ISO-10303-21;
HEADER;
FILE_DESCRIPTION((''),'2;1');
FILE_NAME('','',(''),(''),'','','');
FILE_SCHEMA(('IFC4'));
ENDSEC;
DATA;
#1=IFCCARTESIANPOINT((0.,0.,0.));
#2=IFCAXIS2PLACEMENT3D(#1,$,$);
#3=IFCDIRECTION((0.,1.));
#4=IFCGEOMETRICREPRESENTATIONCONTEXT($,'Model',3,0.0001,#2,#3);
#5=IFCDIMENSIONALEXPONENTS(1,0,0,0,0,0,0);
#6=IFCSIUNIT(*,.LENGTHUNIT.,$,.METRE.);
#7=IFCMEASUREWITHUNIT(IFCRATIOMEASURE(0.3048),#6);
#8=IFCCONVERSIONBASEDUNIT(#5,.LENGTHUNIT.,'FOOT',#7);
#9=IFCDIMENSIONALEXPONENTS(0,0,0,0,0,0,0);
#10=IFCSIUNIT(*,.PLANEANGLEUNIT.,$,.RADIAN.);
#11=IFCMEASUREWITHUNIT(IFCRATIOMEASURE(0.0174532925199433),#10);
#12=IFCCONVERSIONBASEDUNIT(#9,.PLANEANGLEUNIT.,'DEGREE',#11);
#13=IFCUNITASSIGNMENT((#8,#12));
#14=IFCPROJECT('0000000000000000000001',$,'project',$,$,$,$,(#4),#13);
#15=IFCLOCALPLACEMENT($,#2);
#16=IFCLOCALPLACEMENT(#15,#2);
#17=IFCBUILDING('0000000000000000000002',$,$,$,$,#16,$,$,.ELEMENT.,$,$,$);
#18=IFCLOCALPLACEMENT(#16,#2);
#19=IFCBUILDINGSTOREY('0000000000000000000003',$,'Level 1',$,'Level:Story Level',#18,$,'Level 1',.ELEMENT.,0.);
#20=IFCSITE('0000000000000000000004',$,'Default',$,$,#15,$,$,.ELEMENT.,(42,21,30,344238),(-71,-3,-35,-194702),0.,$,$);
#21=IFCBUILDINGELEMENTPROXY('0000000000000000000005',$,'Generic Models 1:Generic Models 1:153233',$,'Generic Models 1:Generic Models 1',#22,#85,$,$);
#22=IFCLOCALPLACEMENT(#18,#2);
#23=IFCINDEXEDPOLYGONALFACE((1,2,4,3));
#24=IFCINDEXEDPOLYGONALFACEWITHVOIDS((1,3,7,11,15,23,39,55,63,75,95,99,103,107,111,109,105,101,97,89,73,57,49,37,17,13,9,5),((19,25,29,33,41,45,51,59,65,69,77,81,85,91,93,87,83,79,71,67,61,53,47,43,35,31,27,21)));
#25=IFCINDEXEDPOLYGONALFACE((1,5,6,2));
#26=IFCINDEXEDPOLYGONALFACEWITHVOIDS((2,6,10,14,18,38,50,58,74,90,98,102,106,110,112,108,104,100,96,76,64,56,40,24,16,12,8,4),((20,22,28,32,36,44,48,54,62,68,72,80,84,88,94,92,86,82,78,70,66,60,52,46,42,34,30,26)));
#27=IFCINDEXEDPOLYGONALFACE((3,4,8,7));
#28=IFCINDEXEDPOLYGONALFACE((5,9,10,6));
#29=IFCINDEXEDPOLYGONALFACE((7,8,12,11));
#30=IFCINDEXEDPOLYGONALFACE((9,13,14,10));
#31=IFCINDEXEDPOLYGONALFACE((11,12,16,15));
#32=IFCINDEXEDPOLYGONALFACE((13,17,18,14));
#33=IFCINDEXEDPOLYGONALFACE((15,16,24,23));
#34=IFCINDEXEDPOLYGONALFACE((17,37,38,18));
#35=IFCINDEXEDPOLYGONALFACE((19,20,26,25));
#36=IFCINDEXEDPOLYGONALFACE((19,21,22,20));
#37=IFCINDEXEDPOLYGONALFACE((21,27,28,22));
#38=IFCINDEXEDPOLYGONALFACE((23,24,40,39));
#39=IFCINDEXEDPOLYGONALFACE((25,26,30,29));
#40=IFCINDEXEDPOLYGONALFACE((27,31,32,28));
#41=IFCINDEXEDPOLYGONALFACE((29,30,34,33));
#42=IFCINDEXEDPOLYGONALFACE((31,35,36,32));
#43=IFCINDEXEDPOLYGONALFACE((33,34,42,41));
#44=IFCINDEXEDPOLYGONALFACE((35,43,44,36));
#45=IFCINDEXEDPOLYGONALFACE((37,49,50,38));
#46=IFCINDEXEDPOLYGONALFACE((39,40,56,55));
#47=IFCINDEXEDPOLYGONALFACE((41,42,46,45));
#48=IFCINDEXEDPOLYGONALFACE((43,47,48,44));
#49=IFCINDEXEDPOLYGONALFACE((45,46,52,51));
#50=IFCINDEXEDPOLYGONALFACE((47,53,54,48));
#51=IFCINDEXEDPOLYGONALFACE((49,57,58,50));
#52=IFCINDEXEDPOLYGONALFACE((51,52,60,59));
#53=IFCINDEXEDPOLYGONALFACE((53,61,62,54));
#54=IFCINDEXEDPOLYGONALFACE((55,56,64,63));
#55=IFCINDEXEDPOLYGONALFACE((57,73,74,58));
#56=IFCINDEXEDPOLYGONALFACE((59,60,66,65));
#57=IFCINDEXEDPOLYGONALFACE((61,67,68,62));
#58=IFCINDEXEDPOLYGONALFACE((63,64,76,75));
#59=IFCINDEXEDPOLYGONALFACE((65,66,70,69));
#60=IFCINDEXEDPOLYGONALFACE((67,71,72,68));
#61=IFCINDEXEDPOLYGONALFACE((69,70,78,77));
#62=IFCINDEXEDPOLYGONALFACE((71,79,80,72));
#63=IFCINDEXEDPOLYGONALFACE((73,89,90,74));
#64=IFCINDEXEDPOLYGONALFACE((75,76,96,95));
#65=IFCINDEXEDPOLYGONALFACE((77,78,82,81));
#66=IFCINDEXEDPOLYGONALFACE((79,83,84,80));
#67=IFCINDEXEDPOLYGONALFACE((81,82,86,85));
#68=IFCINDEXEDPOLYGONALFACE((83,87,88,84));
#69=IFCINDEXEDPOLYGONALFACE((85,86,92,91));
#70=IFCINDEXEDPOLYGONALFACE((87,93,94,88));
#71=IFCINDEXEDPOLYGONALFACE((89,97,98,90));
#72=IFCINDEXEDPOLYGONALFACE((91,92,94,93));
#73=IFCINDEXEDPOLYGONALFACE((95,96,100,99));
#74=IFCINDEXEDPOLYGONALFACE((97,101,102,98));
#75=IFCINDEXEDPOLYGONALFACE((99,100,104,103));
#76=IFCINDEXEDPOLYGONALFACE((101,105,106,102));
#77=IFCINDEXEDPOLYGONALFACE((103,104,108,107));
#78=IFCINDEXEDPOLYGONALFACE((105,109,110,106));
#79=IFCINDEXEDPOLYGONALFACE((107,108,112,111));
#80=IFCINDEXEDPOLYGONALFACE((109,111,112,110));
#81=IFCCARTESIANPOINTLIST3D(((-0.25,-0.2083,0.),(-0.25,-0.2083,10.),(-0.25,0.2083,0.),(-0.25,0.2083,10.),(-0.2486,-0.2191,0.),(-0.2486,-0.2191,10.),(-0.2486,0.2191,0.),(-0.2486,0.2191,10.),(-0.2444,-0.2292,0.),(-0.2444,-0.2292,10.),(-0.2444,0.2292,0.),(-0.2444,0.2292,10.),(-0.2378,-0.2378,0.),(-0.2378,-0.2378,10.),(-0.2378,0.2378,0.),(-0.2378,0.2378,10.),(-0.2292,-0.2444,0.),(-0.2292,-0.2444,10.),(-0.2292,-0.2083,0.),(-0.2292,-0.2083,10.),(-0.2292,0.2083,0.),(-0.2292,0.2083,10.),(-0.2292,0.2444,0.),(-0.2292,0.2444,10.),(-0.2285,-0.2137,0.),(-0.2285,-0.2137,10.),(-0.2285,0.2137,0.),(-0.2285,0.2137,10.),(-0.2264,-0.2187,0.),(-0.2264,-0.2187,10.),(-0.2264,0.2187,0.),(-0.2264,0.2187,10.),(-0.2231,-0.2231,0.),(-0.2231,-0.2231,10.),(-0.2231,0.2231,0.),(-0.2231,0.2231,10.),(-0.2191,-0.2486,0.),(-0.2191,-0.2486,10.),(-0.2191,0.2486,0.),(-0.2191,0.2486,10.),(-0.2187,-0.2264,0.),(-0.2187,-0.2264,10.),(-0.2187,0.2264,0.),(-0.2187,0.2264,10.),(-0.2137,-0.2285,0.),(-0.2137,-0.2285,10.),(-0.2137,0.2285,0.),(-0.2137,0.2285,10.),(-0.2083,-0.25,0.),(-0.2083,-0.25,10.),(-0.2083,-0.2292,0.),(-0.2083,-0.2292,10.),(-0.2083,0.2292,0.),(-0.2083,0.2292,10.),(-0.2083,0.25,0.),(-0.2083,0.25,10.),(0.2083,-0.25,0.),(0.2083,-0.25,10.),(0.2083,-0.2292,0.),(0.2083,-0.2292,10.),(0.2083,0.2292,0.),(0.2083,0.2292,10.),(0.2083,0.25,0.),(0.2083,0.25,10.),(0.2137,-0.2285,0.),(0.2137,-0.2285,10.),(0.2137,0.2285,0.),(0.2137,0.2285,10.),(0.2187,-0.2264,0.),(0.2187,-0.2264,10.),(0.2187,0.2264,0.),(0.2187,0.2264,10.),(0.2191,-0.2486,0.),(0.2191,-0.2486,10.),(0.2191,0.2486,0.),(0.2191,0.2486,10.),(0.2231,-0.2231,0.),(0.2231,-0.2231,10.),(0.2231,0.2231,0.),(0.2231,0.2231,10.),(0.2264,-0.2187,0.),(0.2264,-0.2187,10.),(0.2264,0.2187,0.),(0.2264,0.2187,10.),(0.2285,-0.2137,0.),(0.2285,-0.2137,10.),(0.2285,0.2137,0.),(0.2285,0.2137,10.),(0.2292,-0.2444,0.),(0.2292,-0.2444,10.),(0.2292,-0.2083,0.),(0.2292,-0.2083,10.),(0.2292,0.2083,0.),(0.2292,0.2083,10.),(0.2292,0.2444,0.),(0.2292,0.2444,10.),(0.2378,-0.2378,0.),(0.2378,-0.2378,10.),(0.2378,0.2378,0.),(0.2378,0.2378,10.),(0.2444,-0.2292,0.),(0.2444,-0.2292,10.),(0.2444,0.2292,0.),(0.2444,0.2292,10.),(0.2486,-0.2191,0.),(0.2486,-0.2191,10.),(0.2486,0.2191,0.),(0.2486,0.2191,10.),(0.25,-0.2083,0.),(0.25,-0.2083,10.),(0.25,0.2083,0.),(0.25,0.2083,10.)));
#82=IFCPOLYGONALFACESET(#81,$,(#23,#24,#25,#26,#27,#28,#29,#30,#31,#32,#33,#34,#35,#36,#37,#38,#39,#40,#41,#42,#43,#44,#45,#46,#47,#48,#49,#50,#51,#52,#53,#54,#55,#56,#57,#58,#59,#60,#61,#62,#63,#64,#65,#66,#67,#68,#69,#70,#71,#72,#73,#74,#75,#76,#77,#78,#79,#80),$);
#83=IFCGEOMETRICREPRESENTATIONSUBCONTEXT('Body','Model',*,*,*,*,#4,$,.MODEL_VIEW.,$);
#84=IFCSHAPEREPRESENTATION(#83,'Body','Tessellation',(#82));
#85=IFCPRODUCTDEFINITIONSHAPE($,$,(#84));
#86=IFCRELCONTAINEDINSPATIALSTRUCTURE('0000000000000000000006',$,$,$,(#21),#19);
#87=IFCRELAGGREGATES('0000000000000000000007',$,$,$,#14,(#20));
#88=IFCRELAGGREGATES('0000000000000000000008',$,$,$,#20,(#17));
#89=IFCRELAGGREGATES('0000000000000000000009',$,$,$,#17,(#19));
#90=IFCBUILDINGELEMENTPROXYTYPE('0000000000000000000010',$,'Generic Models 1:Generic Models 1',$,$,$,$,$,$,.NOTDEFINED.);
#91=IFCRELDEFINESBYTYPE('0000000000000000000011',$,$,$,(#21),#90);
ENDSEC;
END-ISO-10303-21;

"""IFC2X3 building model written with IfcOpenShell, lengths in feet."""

from ifc_helpers import new_model, entity, si_unit, converted_unit, direction, frame, frame_2d, origin, place, context, subcontext, project, spatial, polyline, circle_curve, parameter, trimmed, segment, composite_curve, outline, extrude, source, transform, mapped, type_object, type_shapes, element, save


model = new_model("IFC2X3")

# Units and contexts
model_context = context("Model", 3, precision=0.0001, world=origin(), true_north=direction((0.0, 1.0)))
body_context = subcontext(model_context, "Body", "Model", "MODEL_VIEW")
ifc_project = project(units=[converted_unit("LENGTHUNIT", "FOOT", entity("IfcRatioMeasure", 0.3048), si_unit("LENGTHUNIT", "METRE"), dimensions=[1, 0, 0, 0, 0, 0, 0]), converted_unit("PLANEANGLEUNIT", "DEGREE", entity("IfcRatioMeasure", 0.0174532925199433), si_unit("PLANEANGLEUNIT", "RADIAN"), dimensions=[0, 0, 0, 0, 0, 0, 0])], contexts=[model_context])

# Site, building, storey
site_placement = place(None, origin())
site = spatial("IfcSite", under=ifc_project, at=site_placement, Name="Default", CompositionType="ELEMENT", RefLatitude=(42, 21, 30, 344238), RefLongitude=(-71, -3, -35, -194702), RefElevation=0.0)
building_placement = place(site_placement, origin())
building = spatial("IfcBuilding", under=site, at=building_placement, CompositionType="ELEMENT")
storey_placement = place(building_placement, origin())
storey = spatial("IfcBuildingStorey", under=building, at=storey_placement, Name="Level 1", ObjectType="Level:Story Level", LongName="Level 1", CompositionType="ELEMENT", Elevation=0.0)

# Building element proxy
building_element_proxy_type = type_object("IfcBuildingElementProxyType", Name="Generic Models 1:Generic Models 1", PredefinedType="NOTDEFINED")
shared_shape = source(origin(), body_context, "Body", "SweptSolid", [
    extrude(outline(composite_curve([segment(polyline([(-0.2083, -0.25), (0.2083, -0.25)]), True, "CONTINUOUS"), segment(trimmed(circle_curve(frame_2d((0.2083, -0.2083), x_axis=(-1.0, 0.0)), 0.0417), [parameter(90.0)], [parameter(180.0)], True, "PARAMETER"), True, "CONTINUOUS"), segment(polyline([(0.25, -0.2083), (0.25, 0.2083)]), True, "CONTINUOUS"), segment(trimmed(circle_curve(frame_2d((0.2083, 0.2083), x_axis=(-1.0, 0.0)), 0.0417), [parameter(180.0)], [parameter(270.0)], True, "PARAMETER"), True, "CONTINUOUS"), segment(polyline([(0.2083, 0.25), (-0.2083, 0.25)]), True, "CONTINUOUS"), segment(trimmed(circle_curve(frame_2d((-0.2083, 0.2083), x_axis=(-1.0, 0.0)), 0.0417), [parameter(270.0)], [parameter(0.0)], True, "PARAMETER"), True, "CONTINUOUS"), segment(polyline([(-0.25, 0.2083), (-0.25, -0.2083)]), True, "CONTINUOUS"), segment(trimmed(circle_curve(frame_2d((-0.2083, -0.2083), x_axis=(-1.0, 0.0)), 0.0417), [parameter(0.0)], [parameter(90.0)], True, "PARAMETER"), True, "CONTINUOUS")], self_intersect=False), holes=[composite_curve([segment(trimmed(circle_curve(frame_2d((-0.2083, -0.2083), x_axis=(-1.0, 0.0)), 0.0208), [parameter(0.0)], [parameter(90.0)], True, "PARAMETER"), False, "CONTINUOUS"), segment(polyline([(-0.2292, -0.2083), (-0.2292, 0.2083)]), True, "CONTINUOUS"), segment(trimmed(circle_curve(frame_2d((-0.2083, 0.2083), x_axis=(-1.0, 0.0)), 0.0208), [parameter(270.0)], [parameter(0.0)], True, "PARAMETER"), False, "CONTINUOUS"), segment(polyline([(-0.2083, 0.2292), (0.2083, 0.2292)]), True, "CONTINUOUS"), segment(trimmed(circle_curve(frame_2d((0.2083, 0.2083), x_axis=(-1.0, 0.0)), 0.0208), [parameter(180.0)], [parameter(270.0)], True, "PARAMETER"), False, "CONTINUOUS"), segment(polyline([(0.2292, 0.2083), (0.2292, -0.2083)]), True, "CONTINUOUS"), segment(trimmed(circle_curve(frame_2d((0.2083, -0.2083), x_axis=(-1.0, 0.0)), 0.0208), [parameter(90.0)], [parameter(180.0)], True, "PARAMETER"), False, "CONTINUOUS"), segment(polyline([(0.2083, -0.2292), (-0.2083, -0.2292)]), True, "CONTINUOUS")], self_intersect=False)]), frame((0.0, 0.0, 0.0), z_axis=(0.0, 0.0, 1.0), x_axis=(-1.0, 0.0, 0.0)), (0.0, 0.0, 1.0), 10.0),
])
type_shapes(building_element_proxy_type, [shared_shape])
proxy_placement = place(storey_placement, origin())
element("IfcBuildingElementProxy", 1, at=proxy_placement, inside=storey, type_object=building_element_proxy_type, Name="Generic Models 1:Generic Models 1:153233", ObjectType="Generic Models 1:Generic Models 1", context=body_context, shape_type="MappedRepresentation", body=[
    mapped(shared_shape, transform((0.0, 0.0, 0.0), scale=1.0)),
])

save(model, "model.ifc")
